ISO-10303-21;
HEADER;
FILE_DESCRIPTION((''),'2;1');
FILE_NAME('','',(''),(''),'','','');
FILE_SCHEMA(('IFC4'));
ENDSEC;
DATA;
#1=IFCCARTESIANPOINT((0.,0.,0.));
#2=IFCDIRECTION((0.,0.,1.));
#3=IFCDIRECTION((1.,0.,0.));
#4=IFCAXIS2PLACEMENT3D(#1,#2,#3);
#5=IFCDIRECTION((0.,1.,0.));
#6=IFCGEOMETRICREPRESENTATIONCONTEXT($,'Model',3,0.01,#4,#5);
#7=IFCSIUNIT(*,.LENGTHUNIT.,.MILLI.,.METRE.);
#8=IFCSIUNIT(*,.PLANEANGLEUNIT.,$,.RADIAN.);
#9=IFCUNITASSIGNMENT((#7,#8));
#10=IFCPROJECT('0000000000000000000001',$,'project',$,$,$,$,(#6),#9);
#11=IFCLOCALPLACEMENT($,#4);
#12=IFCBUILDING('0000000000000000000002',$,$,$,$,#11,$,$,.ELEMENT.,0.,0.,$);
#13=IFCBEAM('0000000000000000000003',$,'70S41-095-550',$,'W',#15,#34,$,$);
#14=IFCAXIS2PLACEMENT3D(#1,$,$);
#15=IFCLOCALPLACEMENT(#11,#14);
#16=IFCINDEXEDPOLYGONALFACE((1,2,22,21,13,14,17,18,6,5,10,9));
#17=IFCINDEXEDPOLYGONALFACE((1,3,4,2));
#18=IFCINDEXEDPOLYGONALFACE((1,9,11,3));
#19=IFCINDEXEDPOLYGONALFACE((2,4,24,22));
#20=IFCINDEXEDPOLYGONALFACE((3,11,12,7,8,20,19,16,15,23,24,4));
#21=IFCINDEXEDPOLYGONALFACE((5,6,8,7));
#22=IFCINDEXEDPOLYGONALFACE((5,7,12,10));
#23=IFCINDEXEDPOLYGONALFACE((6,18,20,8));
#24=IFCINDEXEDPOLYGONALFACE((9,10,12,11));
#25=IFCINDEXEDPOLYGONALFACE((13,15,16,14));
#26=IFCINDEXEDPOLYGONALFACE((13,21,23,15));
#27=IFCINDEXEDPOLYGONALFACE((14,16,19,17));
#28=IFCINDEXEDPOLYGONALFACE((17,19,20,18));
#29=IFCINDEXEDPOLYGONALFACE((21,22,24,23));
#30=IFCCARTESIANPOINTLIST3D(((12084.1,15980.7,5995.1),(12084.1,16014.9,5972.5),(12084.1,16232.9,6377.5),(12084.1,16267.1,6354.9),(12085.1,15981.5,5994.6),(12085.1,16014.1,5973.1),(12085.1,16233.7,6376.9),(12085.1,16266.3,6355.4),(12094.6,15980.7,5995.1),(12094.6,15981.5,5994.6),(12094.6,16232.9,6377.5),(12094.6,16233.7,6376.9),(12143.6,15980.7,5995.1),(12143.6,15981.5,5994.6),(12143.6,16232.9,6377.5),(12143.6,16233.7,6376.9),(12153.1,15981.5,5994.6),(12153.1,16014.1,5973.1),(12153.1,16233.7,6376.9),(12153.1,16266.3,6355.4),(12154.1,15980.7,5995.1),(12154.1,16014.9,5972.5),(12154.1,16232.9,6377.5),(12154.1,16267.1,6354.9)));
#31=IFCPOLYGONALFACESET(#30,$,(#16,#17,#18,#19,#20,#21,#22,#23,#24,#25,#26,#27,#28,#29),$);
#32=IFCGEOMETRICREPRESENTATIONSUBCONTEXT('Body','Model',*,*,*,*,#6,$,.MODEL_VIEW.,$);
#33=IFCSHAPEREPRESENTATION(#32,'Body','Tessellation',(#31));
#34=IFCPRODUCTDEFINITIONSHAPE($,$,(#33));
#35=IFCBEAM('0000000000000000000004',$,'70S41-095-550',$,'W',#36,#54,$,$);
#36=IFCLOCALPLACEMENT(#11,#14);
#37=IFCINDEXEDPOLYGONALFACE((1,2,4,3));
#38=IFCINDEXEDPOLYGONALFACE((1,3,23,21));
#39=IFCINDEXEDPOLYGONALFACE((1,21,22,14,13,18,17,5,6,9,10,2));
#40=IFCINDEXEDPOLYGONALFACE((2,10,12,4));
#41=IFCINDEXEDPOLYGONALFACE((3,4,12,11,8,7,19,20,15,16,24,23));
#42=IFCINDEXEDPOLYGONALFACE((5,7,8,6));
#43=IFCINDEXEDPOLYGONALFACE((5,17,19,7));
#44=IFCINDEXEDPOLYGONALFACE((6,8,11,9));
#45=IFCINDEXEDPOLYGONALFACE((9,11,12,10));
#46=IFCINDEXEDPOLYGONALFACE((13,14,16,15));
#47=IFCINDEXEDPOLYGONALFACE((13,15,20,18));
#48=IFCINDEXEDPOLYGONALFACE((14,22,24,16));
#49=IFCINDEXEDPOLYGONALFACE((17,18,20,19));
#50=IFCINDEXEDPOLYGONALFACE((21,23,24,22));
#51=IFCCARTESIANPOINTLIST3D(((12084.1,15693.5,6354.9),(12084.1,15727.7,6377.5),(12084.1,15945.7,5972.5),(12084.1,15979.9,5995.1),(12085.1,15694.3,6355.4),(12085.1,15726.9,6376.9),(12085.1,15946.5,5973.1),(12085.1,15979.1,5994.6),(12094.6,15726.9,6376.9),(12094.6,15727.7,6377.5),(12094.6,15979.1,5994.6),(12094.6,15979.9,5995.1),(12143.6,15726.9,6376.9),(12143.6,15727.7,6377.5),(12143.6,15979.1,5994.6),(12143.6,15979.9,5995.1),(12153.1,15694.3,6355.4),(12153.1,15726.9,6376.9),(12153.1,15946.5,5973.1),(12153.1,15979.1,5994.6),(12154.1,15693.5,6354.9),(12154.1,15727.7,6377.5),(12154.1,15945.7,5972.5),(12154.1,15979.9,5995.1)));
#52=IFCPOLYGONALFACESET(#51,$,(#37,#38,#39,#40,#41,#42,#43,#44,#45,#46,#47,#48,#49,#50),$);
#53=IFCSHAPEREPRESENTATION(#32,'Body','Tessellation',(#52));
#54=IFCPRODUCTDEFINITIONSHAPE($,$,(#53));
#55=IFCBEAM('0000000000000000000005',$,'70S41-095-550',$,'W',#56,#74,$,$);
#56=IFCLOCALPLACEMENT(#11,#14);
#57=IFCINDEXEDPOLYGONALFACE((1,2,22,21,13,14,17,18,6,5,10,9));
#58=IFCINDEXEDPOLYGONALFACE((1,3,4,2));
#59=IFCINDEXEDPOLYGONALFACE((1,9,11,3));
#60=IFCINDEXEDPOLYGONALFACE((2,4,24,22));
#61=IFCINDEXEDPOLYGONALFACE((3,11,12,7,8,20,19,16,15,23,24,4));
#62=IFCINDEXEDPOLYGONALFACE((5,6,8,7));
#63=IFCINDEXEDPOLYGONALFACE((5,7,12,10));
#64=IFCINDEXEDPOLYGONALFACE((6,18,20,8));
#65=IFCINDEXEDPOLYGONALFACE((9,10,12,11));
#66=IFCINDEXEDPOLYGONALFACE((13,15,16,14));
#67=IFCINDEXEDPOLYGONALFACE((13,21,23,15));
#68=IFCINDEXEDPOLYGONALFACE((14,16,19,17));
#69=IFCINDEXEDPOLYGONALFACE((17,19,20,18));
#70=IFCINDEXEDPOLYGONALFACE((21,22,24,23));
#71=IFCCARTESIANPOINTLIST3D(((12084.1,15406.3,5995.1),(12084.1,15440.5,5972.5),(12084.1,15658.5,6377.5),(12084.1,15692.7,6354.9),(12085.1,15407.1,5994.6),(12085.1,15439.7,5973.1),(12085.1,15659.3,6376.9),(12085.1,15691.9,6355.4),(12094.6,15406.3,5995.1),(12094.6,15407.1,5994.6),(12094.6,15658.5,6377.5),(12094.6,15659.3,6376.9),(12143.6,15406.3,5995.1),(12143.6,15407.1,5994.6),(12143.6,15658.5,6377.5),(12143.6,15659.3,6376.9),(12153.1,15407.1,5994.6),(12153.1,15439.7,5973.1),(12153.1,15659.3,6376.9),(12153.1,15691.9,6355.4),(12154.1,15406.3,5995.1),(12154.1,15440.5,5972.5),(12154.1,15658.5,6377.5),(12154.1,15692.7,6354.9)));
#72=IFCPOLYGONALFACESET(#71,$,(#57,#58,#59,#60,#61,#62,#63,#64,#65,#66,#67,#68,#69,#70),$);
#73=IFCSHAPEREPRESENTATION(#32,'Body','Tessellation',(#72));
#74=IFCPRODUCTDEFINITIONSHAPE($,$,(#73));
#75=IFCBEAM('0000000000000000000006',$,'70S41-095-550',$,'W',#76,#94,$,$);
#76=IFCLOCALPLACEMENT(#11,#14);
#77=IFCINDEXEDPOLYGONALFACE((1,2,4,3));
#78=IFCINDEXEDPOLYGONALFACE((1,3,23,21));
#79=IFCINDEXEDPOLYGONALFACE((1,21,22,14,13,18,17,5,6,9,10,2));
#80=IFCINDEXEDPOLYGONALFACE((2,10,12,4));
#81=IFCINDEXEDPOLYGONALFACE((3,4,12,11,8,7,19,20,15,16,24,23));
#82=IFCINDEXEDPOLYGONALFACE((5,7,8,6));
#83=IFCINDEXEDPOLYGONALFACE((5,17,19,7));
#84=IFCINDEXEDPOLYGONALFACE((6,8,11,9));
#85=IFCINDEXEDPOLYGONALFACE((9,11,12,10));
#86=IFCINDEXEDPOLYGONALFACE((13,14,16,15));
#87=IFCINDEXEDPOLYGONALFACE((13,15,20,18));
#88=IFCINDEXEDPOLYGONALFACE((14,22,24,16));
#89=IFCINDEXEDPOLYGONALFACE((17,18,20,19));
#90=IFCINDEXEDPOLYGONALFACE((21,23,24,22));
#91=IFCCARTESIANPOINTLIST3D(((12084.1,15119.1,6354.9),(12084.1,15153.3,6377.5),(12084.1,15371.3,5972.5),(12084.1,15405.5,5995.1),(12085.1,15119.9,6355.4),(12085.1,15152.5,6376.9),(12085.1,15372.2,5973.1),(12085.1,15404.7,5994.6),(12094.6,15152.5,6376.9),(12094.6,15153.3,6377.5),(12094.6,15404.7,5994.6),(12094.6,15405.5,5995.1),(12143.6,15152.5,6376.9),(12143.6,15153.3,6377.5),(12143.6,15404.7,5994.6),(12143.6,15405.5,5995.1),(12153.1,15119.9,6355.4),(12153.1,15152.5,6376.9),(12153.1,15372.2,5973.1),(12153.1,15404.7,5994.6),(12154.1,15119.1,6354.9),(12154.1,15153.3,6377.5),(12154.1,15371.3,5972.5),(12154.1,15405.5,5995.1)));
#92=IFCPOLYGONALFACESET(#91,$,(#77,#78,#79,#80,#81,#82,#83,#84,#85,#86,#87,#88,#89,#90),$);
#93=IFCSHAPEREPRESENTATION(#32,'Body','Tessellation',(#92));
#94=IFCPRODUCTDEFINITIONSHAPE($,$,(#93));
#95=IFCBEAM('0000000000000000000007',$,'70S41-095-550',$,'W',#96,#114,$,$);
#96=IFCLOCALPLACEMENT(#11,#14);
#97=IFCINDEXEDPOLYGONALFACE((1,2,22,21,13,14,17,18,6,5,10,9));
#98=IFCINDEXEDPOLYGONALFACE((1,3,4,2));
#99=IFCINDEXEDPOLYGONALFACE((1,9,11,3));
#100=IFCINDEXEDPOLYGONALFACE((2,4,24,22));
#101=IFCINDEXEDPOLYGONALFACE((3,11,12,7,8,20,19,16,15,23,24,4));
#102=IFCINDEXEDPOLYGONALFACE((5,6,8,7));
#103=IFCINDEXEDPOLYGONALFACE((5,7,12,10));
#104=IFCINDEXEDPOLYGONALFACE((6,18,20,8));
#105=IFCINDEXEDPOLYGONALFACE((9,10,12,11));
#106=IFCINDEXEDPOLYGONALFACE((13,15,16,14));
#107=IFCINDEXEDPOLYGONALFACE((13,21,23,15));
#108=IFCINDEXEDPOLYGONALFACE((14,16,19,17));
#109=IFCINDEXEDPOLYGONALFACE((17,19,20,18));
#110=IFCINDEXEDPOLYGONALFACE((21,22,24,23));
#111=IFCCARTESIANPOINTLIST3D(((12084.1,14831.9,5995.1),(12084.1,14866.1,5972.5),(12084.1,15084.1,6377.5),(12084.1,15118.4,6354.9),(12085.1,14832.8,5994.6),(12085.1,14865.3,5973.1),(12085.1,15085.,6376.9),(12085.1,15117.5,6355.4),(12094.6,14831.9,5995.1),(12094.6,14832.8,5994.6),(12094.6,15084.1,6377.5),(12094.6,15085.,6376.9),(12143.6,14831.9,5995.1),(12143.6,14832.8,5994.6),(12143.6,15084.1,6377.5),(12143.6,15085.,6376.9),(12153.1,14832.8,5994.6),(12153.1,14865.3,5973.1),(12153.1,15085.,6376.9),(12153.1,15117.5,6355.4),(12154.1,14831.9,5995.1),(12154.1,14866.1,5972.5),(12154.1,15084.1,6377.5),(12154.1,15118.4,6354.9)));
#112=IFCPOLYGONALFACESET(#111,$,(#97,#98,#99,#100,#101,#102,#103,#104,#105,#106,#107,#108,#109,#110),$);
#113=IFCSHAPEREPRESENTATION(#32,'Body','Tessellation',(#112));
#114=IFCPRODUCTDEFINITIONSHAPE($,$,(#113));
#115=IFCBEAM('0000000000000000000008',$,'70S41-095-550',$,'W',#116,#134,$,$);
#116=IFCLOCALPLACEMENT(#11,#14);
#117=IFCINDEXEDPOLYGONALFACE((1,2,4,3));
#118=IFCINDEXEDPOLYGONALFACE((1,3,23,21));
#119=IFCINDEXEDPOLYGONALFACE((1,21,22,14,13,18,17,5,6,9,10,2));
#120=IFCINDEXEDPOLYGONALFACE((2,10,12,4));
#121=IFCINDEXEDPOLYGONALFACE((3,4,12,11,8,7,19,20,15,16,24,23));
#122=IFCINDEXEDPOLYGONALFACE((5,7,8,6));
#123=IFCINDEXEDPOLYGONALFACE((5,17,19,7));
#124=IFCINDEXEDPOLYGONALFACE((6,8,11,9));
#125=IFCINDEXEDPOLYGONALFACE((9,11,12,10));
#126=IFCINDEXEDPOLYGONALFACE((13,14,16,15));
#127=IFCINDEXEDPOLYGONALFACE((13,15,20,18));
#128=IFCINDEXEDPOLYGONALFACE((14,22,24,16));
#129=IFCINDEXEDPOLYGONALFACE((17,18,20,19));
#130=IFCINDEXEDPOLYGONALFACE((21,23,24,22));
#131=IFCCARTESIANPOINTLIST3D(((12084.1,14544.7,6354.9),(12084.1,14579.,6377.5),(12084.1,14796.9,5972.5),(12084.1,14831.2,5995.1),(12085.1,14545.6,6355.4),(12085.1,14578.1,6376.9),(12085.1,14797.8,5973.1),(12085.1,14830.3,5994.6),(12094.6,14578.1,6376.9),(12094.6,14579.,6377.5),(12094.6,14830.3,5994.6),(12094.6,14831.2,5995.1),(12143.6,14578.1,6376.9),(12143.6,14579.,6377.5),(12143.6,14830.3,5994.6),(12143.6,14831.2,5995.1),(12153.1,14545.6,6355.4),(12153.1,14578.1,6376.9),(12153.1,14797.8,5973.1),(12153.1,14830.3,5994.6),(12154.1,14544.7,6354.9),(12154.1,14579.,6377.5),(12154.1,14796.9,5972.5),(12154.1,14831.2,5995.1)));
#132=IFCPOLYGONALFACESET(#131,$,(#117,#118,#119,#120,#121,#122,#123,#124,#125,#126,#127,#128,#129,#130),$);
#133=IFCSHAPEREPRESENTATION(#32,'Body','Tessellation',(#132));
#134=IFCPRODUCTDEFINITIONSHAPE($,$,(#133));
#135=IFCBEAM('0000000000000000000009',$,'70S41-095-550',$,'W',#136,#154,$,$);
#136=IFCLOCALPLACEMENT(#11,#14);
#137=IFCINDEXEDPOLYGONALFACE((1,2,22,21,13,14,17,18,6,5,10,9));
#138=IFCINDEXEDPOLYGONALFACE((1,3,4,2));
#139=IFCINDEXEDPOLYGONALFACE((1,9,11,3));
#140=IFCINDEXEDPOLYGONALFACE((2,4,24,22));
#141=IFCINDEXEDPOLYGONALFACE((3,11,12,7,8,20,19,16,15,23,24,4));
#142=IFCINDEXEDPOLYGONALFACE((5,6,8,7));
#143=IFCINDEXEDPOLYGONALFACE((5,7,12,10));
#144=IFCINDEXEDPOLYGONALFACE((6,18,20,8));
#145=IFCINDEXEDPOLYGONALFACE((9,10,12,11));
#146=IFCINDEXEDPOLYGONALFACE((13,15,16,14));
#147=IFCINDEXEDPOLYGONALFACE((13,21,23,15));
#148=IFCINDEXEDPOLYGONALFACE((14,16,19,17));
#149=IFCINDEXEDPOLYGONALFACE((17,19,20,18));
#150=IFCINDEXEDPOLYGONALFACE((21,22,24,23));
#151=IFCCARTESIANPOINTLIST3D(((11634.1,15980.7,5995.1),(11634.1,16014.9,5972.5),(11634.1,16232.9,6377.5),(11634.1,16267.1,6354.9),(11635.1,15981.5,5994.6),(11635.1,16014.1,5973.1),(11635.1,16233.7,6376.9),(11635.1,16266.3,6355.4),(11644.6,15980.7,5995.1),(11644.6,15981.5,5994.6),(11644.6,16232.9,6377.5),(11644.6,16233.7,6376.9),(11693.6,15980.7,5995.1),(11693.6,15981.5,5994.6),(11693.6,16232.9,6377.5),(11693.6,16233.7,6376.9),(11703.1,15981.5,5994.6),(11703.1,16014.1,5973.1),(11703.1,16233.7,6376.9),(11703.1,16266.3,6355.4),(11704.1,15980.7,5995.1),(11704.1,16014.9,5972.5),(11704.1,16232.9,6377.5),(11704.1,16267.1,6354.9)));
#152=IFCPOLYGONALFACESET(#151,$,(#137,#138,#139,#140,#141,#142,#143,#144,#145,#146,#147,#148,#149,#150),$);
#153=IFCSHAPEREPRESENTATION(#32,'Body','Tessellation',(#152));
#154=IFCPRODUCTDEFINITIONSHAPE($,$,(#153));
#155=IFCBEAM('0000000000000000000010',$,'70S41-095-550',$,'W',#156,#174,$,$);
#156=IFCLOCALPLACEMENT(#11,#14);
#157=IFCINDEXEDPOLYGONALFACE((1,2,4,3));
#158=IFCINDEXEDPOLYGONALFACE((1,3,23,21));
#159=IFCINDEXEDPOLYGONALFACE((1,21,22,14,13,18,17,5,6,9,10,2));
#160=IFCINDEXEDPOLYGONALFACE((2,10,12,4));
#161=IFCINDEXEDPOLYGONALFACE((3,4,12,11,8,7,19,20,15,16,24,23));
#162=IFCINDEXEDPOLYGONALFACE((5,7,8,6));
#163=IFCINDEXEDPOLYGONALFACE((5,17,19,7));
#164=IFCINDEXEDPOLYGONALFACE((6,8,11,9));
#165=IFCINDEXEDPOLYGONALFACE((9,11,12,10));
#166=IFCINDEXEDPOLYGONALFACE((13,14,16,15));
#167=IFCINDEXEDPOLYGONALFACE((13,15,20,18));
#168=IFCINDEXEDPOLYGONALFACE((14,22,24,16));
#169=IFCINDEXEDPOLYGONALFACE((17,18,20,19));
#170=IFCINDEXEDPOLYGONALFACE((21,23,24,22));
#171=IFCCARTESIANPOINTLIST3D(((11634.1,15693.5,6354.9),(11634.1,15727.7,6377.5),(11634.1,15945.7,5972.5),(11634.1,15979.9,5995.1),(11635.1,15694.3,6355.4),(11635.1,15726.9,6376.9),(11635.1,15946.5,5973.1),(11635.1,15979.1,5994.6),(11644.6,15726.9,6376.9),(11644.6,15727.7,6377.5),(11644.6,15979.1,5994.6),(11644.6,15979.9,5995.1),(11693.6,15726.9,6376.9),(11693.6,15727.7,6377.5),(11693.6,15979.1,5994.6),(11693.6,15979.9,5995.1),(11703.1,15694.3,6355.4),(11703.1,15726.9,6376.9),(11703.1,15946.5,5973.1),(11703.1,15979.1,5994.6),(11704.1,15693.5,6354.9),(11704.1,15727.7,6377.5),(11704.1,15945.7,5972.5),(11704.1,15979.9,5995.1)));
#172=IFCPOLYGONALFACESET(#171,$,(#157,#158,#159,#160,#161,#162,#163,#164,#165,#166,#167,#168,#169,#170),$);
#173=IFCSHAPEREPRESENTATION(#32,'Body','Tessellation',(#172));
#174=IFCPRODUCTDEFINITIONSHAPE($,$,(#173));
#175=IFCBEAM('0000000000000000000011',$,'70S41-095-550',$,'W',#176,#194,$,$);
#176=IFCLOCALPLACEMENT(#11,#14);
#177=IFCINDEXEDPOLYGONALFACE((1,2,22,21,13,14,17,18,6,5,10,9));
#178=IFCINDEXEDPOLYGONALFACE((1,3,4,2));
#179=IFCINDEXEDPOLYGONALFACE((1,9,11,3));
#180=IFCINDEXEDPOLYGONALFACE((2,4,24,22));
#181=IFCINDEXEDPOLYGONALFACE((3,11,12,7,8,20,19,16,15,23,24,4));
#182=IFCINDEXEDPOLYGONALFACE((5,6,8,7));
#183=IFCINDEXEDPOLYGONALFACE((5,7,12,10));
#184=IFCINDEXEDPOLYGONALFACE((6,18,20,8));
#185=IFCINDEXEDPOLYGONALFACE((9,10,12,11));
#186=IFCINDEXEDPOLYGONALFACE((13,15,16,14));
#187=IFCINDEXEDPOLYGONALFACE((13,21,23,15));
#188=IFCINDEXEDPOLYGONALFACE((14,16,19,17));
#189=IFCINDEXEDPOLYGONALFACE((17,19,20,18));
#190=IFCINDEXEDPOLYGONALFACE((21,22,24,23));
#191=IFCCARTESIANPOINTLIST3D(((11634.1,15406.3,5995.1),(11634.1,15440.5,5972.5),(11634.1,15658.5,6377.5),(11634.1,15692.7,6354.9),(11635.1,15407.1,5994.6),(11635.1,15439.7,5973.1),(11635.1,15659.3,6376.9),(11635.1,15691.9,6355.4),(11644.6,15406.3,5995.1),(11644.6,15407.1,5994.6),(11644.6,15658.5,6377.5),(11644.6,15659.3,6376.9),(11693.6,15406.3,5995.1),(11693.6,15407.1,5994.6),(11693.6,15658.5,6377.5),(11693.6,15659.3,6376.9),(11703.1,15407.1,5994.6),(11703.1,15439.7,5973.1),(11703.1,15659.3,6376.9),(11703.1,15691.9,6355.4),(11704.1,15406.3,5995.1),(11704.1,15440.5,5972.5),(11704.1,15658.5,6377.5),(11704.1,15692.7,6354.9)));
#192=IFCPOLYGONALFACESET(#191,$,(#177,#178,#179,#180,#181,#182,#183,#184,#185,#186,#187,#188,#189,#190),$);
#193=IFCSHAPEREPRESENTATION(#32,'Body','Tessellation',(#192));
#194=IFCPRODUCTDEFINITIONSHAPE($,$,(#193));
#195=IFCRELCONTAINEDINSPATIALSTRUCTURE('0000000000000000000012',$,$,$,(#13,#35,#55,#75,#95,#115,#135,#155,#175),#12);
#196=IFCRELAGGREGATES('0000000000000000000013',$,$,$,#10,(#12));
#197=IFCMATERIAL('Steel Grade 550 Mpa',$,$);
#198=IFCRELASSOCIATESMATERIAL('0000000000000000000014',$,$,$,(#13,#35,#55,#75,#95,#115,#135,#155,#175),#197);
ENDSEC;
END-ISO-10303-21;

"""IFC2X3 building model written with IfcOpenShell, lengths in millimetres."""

from ifc_helpers import new_model, si_unit, direction, frame, origin, origin_with_axes, origin_2d_with_axis, place, context, subcontext, project, spatial, c_section, extrude, source, transform, mapped, material, element, save


model = new_model("IFC2X3")

# Units and contexts
model_context = context("Model", 3, precision=0.01, world=origin_with_axes(), true_north=direction((0.0, 1.0, 0.0)))
body_context = subcontext(model_context, "Body", "Model", "MODEL_VIEW")
ifc_project = project(units=[si_unit("LENGTHUNIT", "METRE", prefix="MILLI"), si_unit("PLANEANGLEUNIT", "RADIAN")], contexts=[model_context])

# Building
building_placement = place(None, origin_with_axes())
building = spatial("IfcBuilding", under=ifc_project, at=building_placement, CompositionType="ELEMENT", ElevationOfRefHeight=0.0, ElevationOfTerrain=0.0)

# Beams
ifc_material = material(Name="Steel Grade 550 Mpa")
shared_shape_1 = source(origin(), body_context, "Body", "SweptSolid", [
    extrude(c_section(Depth=70.0, Width=41.0, WallThickness=1.0, Girth=10.5, at=origin_2d_with_axis()), origin_with_axes(), (0.0, 0.0, 1.0), 458.1),
])
beam_1_placement = place(None, frame((12119.1, 15997.8, 5983.8), z_axis=(0.0, 0.550611, 0.834762), x_axis=(0.0, -0.834762, 0.550611)))
element("IfcBeam", 1, at=beam_1_placement, inside=building, material=ifc_material, Name="70S41-095-550", ObjectType="W", context=body_context, shape_type="MappedRepresentation", body=[
    mapped(shared_shape_1, transform((0.0, 0.0, 0.0), scale=1.0)),
])
shared_shape_2 = source(origin(), body_context, "Body", "SweptSolid", [
    extrude(c_section(Depth=70.0, Width=41.0, WallThickness=1.0, Girth=10.5, at=origin_2d_with_axis()), origin_with_axes(), (0.0, 0.0, 1.0), 458.1),
])
beam_2_placement = place(None, frame((12119.1, 15710.6, 6366.2), z_axis=(0.0, 0.550611, -0.834762), x_axis=(0.0, 0.834762, 0.550611)))
element("IfcBeam", 2, at=beam_2_placement, inside=building, material=ifc_material, Name="70S41-095-550", ObjectType="W", context=body_context, shape_type="MappedRepresentation", body=[
    mapped(shared_shape_2, transform((0.0, 0.0, 0.0), scale=1.0)),
])
shared_shape_3 = source(origin(), body_context, "Body", "SweptSolid", [
    extrude(c_section(Depth=70.0, Width=41.0, WallThickness=1.0, Girth=10.5, at=origin_2d_with_axis()), origin_with_axes(), (0.0, 0.0, 1.0), 458.1),
])
beam_3_placement = place(None, frame((12119.1, 15423.4, 5983.8), z_axis=(0.0, 0.550611, 0.834762), x_axis=(0.0, -0.834762, 0.550611)))
element("IfcBeam", 3, at=beam_3_placement, inside=building, material=ifc_material, Name="70S41-095-550", ObjectType="W", context=body_context, shape_type="MappedRepresentation", body=[
    mapped(shared_shape_3, transform((0.0, 0.0, 0.0), scale=1.0)),
])
shared_shape_4 = source(origin(), body_context, "Body", "SweptSolid", [
    extrude(c_section(Depth=70.0, Width=41.0, WallThickness=1.0, Girth=10.5, at=origin_2d_with_axis()), origin_with_axes(), (0.0, 0.0, 1.0), 458.1),
])
beam_4_placement = place(None, frame((12119.1, 15136.2, 6366.2), z_axis=(0.0, 0.550611, -0.834762), x_axis=(0.0, 0.834762, 0.550611)))
element("IfcBeam", 4, at=beam_4_placement, inside=building, material=ifc_material, Name="70S41-095-550", ObjectType="W", context=body_context, shape_type="MappedRepresentation", body=[
    mapped(shared_shape_4, transform((0.0, 0.0, 0.0), scale=1.0)),
])
shared_shape_5 = source(origin(), body_context, "Body", "SweptSolid", [
    extrude(c_section(Depth=70.0, Width=41.0, WallThickness=1.0, Girth=10.5, at=origin_2d_with_axis()), origin_with_axes(), (0.0, 0.0, 1.0), 458.1),
])
beam_5_placement = place(None, frame((12119.1, 14849.0, 5983.8), z_axis=(0.0, 0.550611, 0.834762), x_axis=(0.0, -0.834762, 0.550611)))
element("IfcBeam", 5, at=beam_5_placement, inside=building, material=ifc_material, Name="70S41-095-550", ObjectType="W", context=body_context, shape_type="MappedRepresentation", body=[
    mapped(shared_shape_5, transform((0.0, 0.0, 0.0), scale=1.0)),
])
shared_shape_6 = source(origin(), body_context, "Body", "SweptSolid", [
    extrude(c_section(Depth=70.0, Width=41.0, WallThickness=1.0, Girth=10.5, at=origin_2d_with_axis()), origin_with_axes(), (0.0, 0.0, 1.0), 458.1),
])
beam_6_placement = place(None, frame((12119.1, 14561.8, 6366.2), z_axis=(0.0, 0.550611, -0.834762), x_axis=(0.0, 0.834762, 0.550611)))
element("IfcBeam", 6, at=beam_6_placement, inside=building, material=ifc_material, Name="70S41-095-550", ObjectType="W", context=body_context, shape_type="MappedRepresentation", body=[
    mapped(shared_shape_6, transform((0.0, 0.0, 0.0), scale=1.0)),
])
shared_shape_7 = source(origin(), body_context, "Body", "SweptSolid", [
    extrude(c_section(Depth=70.0, Width=41.0, WallThickness=1.0, Girth=10.5, at=origin_2d_with_axis()), origin_with_axes(), (0.0, 0.0, 1.0), 458.1),
])
beam_7_placement = place(None, frame((11669.1, 15997.8, 5983.8), z_axis=(0.0, 0.550611, 0.834762), x_axis=(0.0, -0.834762, 0.550611)))
element("IfcBeam", 7, at=beam_7_placement, inside=building, material=ifc_material, Name="70S41-095-550", ObjectType="W", context=body_context, shape_type="MappedRepresentation", body=[
    mapped(shared_shape_7, transform((0.0, 0.0, 0.0), scale=1.0)),
])
shared_shape_8 = source(origin(), body_context, "Body", "SweptSolid", [
    extrude(c_section(Depth=70.0, Width=41.0, WallThickness=1.0, Girth=10.5, at=origin_2d_with_axis()), origin_with_axes(), (0.0, 0.0, 1.0), 458.1),
])
beam_8_placement = place(None, frame((11669.1, 15710.6, 6366.2), z_axis=(0.0, 0.550611, -0.834762), x_axis=(0.0, 0.834762, 0.550611)))
element("IfcBeam", 8, at=beam_8_placement, inside=building, material=ifc_material, Name="70S41-095-550", ObjectType="W", context=body_context, shape_type="MappedRepresentation", body=[
    mapped(shared_shape_8, transform((0.0, 0.0, 0.0), scale=1.0)),
])
shared_shape_9 = source(origin(), body_context, "Body", "SweptSolid", [
    extrude(c_section(Depth=70.0, Width=41.0, WallThickness=1.0, Girth=10.5, at=origin_2d_with_axis()), origin_with_axes(), (0.0, 0.0, 1.0), 458.1),
])
beam_9_placement = place(None, frame((11669.1, 15423.4, 5983.8), z_axis=(0.0, 0.550611, 0.834762), x_axis=(0.0, -0.834762, 0.550611)))
element("IfcBeam", 9, at=beam_9_placement, inside=building, material=ifc_material, Name="70S41-095-550", ObjectType="W", context=body_context, shape_type="MappedRepresentation", body=[
    mapped(shared_shape_9, transform((0.0, 0.0, 0.0), scale=1.0)),
])

save(model, "model.ifc")
